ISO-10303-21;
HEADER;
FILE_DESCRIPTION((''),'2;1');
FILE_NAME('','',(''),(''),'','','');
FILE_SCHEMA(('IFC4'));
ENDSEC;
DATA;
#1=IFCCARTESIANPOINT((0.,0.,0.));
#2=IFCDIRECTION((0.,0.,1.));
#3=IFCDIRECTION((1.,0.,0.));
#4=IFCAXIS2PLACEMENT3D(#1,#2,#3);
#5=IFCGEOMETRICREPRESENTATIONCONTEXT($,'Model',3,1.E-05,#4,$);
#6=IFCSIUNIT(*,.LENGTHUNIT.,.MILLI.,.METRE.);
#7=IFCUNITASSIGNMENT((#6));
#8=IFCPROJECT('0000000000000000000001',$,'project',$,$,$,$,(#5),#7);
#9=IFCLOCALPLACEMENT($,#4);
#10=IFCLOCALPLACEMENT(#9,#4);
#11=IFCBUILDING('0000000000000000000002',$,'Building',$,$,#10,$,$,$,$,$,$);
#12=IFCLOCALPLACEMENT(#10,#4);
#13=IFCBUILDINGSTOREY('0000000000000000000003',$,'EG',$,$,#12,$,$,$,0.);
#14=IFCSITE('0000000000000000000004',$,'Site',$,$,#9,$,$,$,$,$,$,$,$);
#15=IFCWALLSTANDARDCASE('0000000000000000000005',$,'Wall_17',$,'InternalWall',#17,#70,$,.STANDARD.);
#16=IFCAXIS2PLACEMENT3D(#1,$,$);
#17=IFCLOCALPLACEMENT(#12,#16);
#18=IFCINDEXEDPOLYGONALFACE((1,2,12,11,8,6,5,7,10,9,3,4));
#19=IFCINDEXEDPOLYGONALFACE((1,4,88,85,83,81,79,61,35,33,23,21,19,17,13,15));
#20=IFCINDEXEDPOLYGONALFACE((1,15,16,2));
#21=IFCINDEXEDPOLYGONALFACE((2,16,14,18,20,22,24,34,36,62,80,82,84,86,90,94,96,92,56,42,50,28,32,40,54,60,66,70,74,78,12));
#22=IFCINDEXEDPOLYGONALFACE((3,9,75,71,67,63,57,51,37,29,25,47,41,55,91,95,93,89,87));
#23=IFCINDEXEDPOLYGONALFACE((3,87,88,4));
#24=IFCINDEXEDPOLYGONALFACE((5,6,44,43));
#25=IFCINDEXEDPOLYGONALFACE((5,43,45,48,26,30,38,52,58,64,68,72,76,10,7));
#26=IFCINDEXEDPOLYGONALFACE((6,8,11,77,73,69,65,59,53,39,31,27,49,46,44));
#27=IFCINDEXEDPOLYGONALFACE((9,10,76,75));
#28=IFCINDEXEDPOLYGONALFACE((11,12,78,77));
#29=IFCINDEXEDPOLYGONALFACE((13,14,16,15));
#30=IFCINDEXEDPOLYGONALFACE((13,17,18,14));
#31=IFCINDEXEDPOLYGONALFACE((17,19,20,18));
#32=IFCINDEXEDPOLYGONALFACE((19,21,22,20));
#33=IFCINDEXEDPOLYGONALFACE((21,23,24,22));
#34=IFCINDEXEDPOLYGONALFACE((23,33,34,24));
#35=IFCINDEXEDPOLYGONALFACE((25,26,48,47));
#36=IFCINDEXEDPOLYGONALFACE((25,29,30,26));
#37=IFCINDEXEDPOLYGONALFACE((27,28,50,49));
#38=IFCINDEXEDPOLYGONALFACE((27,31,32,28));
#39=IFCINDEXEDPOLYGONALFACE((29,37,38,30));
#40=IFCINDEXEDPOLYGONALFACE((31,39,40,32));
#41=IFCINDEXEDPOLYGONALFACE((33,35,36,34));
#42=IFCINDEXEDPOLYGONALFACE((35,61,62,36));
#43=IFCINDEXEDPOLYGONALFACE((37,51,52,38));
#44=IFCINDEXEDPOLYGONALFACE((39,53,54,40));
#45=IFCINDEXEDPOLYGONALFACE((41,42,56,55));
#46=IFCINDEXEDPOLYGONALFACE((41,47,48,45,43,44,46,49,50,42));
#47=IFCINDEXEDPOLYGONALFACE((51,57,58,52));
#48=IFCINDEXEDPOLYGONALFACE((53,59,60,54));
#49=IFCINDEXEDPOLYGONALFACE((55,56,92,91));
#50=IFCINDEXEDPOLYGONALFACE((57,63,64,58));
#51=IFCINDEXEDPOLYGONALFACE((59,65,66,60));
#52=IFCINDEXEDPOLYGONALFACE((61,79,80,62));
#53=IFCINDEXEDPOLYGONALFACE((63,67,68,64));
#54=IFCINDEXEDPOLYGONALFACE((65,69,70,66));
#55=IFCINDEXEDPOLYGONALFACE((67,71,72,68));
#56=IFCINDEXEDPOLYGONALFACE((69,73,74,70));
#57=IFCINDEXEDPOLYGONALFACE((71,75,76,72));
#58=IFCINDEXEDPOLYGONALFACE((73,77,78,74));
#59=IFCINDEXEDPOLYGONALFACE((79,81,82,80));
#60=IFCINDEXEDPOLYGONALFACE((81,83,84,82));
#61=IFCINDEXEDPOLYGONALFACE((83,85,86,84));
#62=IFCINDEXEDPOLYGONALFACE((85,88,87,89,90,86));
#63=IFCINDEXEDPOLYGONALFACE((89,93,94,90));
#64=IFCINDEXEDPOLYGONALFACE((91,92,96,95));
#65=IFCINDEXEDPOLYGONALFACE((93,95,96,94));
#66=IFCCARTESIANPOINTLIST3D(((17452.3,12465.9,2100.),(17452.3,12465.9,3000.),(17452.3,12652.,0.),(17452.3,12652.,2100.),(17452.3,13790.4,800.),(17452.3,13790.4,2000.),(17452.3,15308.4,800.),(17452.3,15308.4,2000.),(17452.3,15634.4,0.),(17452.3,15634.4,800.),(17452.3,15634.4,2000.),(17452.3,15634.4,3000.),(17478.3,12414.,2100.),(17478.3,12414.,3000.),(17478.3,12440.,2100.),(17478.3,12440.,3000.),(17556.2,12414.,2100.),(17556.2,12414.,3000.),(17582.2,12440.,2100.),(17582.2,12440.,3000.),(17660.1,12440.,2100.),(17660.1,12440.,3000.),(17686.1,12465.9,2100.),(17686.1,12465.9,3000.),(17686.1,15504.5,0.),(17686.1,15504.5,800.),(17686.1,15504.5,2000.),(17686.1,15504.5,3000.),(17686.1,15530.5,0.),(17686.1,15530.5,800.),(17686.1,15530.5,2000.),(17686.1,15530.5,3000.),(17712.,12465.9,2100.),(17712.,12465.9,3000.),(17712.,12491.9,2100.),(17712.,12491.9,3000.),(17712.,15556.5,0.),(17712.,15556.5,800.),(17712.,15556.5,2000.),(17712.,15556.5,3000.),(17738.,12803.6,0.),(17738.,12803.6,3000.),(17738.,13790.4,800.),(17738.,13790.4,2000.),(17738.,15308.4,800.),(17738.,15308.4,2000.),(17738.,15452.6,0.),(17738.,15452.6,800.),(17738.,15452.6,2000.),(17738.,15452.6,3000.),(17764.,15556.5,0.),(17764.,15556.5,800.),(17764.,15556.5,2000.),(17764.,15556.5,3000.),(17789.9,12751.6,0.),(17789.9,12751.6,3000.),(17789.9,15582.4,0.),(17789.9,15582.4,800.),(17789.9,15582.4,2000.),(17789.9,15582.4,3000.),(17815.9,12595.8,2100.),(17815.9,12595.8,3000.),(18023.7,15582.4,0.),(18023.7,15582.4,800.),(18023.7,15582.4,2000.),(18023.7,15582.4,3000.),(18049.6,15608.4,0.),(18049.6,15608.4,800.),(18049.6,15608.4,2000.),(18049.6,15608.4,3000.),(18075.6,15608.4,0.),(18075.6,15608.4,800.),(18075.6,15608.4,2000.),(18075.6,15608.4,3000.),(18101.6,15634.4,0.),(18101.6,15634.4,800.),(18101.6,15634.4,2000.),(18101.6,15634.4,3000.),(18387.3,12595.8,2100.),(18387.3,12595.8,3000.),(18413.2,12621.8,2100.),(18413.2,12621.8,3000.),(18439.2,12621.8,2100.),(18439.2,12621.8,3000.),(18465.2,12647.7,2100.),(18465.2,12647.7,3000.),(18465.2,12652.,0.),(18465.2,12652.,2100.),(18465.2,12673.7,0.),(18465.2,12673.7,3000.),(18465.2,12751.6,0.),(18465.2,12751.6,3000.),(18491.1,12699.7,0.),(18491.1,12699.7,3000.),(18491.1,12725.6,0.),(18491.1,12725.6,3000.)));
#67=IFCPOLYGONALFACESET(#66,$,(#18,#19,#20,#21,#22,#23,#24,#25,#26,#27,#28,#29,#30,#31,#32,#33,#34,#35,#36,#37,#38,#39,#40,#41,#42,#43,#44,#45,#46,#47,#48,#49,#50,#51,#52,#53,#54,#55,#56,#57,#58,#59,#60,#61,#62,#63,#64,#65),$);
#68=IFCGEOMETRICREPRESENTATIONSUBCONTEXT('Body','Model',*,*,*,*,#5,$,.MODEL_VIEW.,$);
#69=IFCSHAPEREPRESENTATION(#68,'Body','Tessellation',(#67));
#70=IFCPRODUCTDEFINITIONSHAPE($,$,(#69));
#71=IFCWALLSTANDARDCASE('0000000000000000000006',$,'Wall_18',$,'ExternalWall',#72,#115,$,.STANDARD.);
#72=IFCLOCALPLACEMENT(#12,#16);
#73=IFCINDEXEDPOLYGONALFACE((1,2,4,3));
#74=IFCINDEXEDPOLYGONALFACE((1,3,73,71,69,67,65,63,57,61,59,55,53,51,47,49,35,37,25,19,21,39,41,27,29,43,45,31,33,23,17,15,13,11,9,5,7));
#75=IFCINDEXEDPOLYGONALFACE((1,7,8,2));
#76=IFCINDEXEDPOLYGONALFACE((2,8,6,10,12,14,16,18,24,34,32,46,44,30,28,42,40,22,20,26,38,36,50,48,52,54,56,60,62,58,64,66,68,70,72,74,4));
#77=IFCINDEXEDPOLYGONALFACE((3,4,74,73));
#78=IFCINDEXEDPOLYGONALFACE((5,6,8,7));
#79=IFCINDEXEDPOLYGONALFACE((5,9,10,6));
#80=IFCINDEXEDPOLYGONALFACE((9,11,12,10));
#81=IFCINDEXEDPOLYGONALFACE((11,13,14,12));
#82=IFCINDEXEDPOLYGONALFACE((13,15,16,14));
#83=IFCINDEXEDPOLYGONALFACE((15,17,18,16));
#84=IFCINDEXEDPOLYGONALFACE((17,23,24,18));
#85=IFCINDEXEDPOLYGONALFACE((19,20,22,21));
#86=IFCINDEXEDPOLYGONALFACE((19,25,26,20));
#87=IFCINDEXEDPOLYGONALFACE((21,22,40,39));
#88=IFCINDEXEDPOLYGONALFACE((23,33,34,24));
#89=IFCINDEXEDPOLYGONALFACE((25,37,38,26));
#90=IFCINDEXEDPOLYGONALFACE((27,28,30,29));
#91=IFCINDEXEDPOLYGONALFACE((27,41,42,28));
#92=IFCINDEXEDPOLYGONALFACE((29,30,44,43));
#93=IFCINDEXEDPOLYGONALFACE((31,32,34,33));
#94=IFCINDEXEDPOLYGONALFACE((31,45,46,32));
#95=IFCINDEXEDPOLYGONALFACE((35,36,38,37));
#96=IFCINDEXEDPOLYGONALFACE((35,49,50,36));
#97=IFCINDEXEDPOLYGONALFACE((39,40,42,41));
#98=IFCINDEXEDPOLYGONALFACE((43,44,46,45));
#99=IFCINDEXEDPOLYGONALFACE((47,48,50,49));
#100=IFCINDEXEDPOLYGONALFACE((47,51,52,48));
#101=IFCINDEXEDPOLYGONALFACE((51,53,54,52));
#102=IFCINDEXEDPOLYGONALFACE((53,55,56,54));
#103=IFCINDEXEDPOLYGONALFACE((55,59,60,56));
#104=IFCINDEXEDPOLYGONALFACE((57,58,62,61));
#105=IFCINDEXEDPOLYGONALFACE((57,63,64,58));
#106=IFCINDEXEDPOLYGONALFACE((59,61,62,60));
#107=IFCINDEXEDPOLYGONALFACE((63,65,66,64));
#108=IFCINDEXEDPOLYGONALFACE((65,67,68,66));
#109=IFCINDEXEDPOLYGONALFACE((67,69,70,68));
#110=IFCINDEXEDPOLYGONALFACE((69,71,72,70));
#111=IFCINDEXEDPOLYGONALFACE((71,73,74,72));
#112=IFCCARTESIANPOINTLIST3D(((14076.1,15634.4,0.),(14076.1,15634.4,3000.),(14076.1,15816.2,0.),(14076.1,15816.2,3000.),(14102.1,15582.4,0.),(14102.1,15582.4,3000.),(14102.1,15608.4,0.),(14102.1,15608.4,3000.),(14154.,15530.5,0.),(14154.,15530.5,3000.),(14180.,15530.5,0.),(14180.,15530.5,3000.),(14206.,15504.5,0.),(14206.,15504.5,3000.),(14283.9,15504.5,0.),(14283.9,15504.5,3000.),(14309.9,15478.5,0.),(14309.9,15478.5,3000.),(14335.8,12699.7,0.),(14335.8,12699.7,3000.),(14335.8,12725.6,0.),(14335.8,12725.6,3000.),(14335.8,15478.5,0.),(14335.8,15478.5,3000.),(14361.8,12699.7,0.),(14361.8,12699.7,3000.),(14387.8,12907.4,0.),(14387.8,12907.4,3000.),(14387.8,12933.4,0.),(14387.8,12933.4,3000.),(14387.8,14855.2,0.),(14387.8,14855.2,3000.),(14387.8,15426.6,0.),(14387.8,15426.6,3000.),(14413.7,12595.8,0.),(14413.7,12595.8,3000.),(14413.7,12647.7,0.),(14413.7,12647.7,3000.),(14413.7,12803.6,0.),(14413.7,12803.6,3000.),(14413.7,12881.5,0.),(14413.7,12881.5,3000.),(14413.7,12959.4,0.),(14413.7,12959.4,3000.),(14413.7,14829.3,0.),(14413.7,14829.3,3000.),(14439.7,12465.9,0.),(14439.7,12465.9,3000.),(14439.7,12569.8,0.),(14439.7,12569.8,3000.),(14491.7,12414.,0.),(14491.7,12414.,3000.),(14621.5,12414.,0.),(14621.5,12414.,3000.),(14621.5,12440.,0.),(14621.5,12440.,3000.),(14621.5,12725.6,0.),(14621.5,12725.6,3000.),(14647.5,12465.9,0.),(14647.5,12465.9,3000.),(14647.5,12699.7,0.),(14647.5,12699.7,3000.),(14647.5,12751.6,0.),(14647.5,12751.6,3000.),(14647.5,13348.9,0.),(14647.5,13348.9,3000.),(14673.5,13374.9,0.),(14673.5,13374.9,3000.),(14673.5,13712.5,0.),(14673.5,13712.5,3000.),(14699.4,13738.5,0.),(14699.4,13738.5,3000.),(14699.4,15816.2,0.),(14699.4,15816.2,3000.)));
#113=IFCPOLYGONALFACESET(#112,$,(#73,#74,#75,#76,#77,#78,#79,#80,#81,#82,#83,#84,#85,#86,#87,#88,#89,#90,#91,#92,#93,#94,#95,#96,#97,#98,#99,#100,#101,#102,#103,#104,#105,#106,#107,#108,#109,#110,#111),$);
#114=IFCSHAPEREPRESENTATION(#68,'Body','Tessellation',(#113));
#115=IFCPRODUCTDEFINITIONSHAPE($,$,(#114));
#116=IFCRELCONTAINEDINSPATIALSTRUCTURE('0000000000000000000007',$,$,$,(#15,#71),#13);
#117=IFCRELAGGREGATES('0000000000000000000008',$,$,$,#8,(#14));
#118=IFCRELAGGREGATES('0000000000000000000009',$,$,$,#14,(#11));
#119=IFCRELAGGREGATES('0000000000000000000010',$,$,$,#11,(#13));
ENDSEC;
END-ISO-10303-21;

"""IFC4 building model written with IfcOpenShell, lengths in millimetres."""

from ifc_helpers import new_model, si_unit, frame, origin_with_axes, place, context, subcontext, project, spatial, polyline, rectangle, outline, extrude, element, save


model = new_model("IFC4")

# Units and contexts
model_context = context("Model", 3, precision=1e-05, world=origin_with_axes())
body_context = subcontext(model_context, "Body", "Model", "MODEL_VIEW")
ifc_project = project(units=[si_unit("LENGTHUNIT", "METRE", prefix="MILLI")], contexts=[model_context])

# Site, building, storey
site_placement = place(None, origin_with_axes())
site = spatial("IfcSite", under=ifc_project, at=site_placement, Name="Site")
building_placement = place(site_placement, origin_with_axes())
building = spatial("IfcBuilding", under=site, at=building_placement, Name="Building")
storey_placement = place(building_placement, origin_with_axes())
storey = spatial("IfcBuildingStorey", under=building, at=storey_placement, Name="EG", Elevation=0.0)

# Wall, openings
wall_1_placement = place(storey_placement, origin_with_axes())
wall_1 = element("IfcWallStandardCase", 1, at=wall_1_placement, inside=storey, Name="Wall_17", ObjectType="InternalWall", PredefinedType="STANDARD", context=body_context, shape_type="SweptSolid", body=[
    extrude(outline(polyline([(17478.3, 12414.0, 0.0), (17478.3, 12440.0, 0.0), (17452.3, 12465.9, 0.0), (17452.3, 15634.4, 0.0), (18101.6, 15634.4, 0.0), (18075.6, 15608.4, 0.0), (18049.6, 15608.4, 0.0), (18023.7, 15582.4, 0.0), (17789.9, 15582.4, 0.0), (17764.0, 15556.5, 0.0), (17712.0, 15556.5, 0.0), (17686.1, 15530.5, 0.0), (17686.1, 15504.5, 0.0), (17738.0, 15452.6, 0.0), (17738.0, 12803.6, 0.0), (17789.9, 12751.6, 0.0), (18465.2, 12751.6, 0.0), (18491.1, 12725.6, 0.0), (18491.1, 12699.7, 0.0), (18465.2, 12673.7, 0.0), (18465.2, 12647.7, 0.0), (18439.2, 12621.8, 0.0), (18413.2, 12621.8, 0.0), (18387.3, 12595.8, 0.0), (17815.9, 12595.8, 0.0), (17712.0, 12491.9, 0.0), (17712.0, 12465.9, 0.0), (17686.1, 12465.9, 0.0), (17660.1, 12440.0, 0.0), (17582.2, 12440.0, 0.0), (17556.2, 12414.0, 0.0), (17478.3, 12414.0, 0.0)])), origin_with_axes(), (0.0, 0.0, 1.0), 3000.0),
])
opening_1_placement = place(wall_1_placement, origin_with_axes())
element("IfcOpeningElement", 2, at=opening_1_placement, inside=storey, cuts=wall_1, context=body_context, shape_type="SweptSolid", body=[
    extrude(rectangle(XDim=450.0, YDim=1038.8), frame((17971.7, 12427.0, 0.0), z_axis=(0.0, 0.0, 1.0), x_axis=(0.0, 1.0, 0.0)), (0.0, 0.0, 1.0), 2100.0),
])
opening_2_placement = place(wall_1_placement, origin_with_axes())
element("IfcOpeningElement", 3, at=opening_2_placement, inside=storey, cuts=wall_1, context=body_context, shape_type="SweptSolid", body=[
    extrude(rectangle(XDim=600.0, YDim=1038.8), frame((17971.7, 15608.4, 800.0), z_axis=(0.0, 0.0, 1.0), x_axis=(0.0, 1.0, 0.0)), (0.0, 0.0, 1.0), 1200.0),
])
opening_3_placement = place(wall_1_placement, origin_with_axes())
element("IfcOpeningElement", 4, at=opening_3_placement, inside=storey, cuts=wall_1, context=body_context, shape_type="SweptSolid", body=[
    extrude(rectangle(XDim=1843.9, YDim=1038.8), frame((17971.7, 14712.4, 800.0), z_axis=(0.0, 0.0, 1.0), x_axis=(0.0, 1.0, 0.0)), (0.0, 0.0, 1.0), 1200.0),
])

# Wall, opening
wall_2_placement = place(storey_placement, origin_with_axes())
wall_2 = element("IfcWallStandardCase", 5, at=wall_2_placement, inside=storey, Name="Wall_18", ObjectType="ExternalWall", PredefinedType="STANDARD", context=body_context, shape_type="SweptSolid", body=[
    extrude(outline(polyline([(14491.7, 12414.0, 0.0), (14439.7, 12465.9, 0.0), (14439.7, 12569.8, 0.0), (14413.7, 12595.8, 0.0), (14413.7, 12647.7, 0.0), (14361.8, 12699.7, 0.0), (14335.8, 12699.7, 0.0), (14335.8, 12725.6, 0.0), (14413.7, 12803.6, 0.0), (14413.7, 12881.5, 0.0), (14387.8, 12907.4, 0.0), (14387.8, 12933.4, 0.0), (14413.7, 12959.4, 0.0), (14413.7, 14829.3, 0.0), (14387.8, 14855.2, 0.0), (14387.8, 15426.6, 0.0), (14335.8, 15478.5, 0.0), (14309.9, 15478.5, 0.0), (14283.9, 15504.5, 0.0), (14206.0, 15504.5, 0.0), (14180.0, 15530.5, 0.0), (14154.0, 15530.5, 0.0), (14102.1, 15582.4, 0.0), (14102.1, 15608.4, 0.0), (14076.1, 15634.4, 0.0), (14076.1, 15816.2, 0.0), (14699.4, 15816.2, 0.0), (14699.4, 13738.5, 0.0), (14673.5, 13712.5, 0.0), (14673.5, 13374.9, 0.0), (14647.5, 13348.9, 0.0), (14647.5, 12751.6, 0.0), (14621.5, 12725.6, 0.0), (14647.5, 12699.7, 0.0), (14647.5, 12465.9, 0.0), (14621.5, 12440.0, 0.0), (14621.5, 12414.0, 0.0), (14491.7, 12414.0, 0.0)])), origin_with_axes(), (0.0, 0.0, 1.0), 3000.0),
])
opening_4_placement = place(wall_2_placement, origin_with_axes())
element("IfcOpeningElement", 6, at=opening_4_placement, inside=storey, cuts=wall_2, context=body_context, shape_type="SweptSolid", body=[
    extrude(rectangle(XDim=900.0, YDim=623.3), frame((14262.5, 11949.6, 0.0), z_axis=(0.0, 0.0, 1.0), x_axis=(0.0, -1.0, 0.0)), (0.0, 0.0, 1.0), 2100.0),
])

save(model, "model.ifc")
